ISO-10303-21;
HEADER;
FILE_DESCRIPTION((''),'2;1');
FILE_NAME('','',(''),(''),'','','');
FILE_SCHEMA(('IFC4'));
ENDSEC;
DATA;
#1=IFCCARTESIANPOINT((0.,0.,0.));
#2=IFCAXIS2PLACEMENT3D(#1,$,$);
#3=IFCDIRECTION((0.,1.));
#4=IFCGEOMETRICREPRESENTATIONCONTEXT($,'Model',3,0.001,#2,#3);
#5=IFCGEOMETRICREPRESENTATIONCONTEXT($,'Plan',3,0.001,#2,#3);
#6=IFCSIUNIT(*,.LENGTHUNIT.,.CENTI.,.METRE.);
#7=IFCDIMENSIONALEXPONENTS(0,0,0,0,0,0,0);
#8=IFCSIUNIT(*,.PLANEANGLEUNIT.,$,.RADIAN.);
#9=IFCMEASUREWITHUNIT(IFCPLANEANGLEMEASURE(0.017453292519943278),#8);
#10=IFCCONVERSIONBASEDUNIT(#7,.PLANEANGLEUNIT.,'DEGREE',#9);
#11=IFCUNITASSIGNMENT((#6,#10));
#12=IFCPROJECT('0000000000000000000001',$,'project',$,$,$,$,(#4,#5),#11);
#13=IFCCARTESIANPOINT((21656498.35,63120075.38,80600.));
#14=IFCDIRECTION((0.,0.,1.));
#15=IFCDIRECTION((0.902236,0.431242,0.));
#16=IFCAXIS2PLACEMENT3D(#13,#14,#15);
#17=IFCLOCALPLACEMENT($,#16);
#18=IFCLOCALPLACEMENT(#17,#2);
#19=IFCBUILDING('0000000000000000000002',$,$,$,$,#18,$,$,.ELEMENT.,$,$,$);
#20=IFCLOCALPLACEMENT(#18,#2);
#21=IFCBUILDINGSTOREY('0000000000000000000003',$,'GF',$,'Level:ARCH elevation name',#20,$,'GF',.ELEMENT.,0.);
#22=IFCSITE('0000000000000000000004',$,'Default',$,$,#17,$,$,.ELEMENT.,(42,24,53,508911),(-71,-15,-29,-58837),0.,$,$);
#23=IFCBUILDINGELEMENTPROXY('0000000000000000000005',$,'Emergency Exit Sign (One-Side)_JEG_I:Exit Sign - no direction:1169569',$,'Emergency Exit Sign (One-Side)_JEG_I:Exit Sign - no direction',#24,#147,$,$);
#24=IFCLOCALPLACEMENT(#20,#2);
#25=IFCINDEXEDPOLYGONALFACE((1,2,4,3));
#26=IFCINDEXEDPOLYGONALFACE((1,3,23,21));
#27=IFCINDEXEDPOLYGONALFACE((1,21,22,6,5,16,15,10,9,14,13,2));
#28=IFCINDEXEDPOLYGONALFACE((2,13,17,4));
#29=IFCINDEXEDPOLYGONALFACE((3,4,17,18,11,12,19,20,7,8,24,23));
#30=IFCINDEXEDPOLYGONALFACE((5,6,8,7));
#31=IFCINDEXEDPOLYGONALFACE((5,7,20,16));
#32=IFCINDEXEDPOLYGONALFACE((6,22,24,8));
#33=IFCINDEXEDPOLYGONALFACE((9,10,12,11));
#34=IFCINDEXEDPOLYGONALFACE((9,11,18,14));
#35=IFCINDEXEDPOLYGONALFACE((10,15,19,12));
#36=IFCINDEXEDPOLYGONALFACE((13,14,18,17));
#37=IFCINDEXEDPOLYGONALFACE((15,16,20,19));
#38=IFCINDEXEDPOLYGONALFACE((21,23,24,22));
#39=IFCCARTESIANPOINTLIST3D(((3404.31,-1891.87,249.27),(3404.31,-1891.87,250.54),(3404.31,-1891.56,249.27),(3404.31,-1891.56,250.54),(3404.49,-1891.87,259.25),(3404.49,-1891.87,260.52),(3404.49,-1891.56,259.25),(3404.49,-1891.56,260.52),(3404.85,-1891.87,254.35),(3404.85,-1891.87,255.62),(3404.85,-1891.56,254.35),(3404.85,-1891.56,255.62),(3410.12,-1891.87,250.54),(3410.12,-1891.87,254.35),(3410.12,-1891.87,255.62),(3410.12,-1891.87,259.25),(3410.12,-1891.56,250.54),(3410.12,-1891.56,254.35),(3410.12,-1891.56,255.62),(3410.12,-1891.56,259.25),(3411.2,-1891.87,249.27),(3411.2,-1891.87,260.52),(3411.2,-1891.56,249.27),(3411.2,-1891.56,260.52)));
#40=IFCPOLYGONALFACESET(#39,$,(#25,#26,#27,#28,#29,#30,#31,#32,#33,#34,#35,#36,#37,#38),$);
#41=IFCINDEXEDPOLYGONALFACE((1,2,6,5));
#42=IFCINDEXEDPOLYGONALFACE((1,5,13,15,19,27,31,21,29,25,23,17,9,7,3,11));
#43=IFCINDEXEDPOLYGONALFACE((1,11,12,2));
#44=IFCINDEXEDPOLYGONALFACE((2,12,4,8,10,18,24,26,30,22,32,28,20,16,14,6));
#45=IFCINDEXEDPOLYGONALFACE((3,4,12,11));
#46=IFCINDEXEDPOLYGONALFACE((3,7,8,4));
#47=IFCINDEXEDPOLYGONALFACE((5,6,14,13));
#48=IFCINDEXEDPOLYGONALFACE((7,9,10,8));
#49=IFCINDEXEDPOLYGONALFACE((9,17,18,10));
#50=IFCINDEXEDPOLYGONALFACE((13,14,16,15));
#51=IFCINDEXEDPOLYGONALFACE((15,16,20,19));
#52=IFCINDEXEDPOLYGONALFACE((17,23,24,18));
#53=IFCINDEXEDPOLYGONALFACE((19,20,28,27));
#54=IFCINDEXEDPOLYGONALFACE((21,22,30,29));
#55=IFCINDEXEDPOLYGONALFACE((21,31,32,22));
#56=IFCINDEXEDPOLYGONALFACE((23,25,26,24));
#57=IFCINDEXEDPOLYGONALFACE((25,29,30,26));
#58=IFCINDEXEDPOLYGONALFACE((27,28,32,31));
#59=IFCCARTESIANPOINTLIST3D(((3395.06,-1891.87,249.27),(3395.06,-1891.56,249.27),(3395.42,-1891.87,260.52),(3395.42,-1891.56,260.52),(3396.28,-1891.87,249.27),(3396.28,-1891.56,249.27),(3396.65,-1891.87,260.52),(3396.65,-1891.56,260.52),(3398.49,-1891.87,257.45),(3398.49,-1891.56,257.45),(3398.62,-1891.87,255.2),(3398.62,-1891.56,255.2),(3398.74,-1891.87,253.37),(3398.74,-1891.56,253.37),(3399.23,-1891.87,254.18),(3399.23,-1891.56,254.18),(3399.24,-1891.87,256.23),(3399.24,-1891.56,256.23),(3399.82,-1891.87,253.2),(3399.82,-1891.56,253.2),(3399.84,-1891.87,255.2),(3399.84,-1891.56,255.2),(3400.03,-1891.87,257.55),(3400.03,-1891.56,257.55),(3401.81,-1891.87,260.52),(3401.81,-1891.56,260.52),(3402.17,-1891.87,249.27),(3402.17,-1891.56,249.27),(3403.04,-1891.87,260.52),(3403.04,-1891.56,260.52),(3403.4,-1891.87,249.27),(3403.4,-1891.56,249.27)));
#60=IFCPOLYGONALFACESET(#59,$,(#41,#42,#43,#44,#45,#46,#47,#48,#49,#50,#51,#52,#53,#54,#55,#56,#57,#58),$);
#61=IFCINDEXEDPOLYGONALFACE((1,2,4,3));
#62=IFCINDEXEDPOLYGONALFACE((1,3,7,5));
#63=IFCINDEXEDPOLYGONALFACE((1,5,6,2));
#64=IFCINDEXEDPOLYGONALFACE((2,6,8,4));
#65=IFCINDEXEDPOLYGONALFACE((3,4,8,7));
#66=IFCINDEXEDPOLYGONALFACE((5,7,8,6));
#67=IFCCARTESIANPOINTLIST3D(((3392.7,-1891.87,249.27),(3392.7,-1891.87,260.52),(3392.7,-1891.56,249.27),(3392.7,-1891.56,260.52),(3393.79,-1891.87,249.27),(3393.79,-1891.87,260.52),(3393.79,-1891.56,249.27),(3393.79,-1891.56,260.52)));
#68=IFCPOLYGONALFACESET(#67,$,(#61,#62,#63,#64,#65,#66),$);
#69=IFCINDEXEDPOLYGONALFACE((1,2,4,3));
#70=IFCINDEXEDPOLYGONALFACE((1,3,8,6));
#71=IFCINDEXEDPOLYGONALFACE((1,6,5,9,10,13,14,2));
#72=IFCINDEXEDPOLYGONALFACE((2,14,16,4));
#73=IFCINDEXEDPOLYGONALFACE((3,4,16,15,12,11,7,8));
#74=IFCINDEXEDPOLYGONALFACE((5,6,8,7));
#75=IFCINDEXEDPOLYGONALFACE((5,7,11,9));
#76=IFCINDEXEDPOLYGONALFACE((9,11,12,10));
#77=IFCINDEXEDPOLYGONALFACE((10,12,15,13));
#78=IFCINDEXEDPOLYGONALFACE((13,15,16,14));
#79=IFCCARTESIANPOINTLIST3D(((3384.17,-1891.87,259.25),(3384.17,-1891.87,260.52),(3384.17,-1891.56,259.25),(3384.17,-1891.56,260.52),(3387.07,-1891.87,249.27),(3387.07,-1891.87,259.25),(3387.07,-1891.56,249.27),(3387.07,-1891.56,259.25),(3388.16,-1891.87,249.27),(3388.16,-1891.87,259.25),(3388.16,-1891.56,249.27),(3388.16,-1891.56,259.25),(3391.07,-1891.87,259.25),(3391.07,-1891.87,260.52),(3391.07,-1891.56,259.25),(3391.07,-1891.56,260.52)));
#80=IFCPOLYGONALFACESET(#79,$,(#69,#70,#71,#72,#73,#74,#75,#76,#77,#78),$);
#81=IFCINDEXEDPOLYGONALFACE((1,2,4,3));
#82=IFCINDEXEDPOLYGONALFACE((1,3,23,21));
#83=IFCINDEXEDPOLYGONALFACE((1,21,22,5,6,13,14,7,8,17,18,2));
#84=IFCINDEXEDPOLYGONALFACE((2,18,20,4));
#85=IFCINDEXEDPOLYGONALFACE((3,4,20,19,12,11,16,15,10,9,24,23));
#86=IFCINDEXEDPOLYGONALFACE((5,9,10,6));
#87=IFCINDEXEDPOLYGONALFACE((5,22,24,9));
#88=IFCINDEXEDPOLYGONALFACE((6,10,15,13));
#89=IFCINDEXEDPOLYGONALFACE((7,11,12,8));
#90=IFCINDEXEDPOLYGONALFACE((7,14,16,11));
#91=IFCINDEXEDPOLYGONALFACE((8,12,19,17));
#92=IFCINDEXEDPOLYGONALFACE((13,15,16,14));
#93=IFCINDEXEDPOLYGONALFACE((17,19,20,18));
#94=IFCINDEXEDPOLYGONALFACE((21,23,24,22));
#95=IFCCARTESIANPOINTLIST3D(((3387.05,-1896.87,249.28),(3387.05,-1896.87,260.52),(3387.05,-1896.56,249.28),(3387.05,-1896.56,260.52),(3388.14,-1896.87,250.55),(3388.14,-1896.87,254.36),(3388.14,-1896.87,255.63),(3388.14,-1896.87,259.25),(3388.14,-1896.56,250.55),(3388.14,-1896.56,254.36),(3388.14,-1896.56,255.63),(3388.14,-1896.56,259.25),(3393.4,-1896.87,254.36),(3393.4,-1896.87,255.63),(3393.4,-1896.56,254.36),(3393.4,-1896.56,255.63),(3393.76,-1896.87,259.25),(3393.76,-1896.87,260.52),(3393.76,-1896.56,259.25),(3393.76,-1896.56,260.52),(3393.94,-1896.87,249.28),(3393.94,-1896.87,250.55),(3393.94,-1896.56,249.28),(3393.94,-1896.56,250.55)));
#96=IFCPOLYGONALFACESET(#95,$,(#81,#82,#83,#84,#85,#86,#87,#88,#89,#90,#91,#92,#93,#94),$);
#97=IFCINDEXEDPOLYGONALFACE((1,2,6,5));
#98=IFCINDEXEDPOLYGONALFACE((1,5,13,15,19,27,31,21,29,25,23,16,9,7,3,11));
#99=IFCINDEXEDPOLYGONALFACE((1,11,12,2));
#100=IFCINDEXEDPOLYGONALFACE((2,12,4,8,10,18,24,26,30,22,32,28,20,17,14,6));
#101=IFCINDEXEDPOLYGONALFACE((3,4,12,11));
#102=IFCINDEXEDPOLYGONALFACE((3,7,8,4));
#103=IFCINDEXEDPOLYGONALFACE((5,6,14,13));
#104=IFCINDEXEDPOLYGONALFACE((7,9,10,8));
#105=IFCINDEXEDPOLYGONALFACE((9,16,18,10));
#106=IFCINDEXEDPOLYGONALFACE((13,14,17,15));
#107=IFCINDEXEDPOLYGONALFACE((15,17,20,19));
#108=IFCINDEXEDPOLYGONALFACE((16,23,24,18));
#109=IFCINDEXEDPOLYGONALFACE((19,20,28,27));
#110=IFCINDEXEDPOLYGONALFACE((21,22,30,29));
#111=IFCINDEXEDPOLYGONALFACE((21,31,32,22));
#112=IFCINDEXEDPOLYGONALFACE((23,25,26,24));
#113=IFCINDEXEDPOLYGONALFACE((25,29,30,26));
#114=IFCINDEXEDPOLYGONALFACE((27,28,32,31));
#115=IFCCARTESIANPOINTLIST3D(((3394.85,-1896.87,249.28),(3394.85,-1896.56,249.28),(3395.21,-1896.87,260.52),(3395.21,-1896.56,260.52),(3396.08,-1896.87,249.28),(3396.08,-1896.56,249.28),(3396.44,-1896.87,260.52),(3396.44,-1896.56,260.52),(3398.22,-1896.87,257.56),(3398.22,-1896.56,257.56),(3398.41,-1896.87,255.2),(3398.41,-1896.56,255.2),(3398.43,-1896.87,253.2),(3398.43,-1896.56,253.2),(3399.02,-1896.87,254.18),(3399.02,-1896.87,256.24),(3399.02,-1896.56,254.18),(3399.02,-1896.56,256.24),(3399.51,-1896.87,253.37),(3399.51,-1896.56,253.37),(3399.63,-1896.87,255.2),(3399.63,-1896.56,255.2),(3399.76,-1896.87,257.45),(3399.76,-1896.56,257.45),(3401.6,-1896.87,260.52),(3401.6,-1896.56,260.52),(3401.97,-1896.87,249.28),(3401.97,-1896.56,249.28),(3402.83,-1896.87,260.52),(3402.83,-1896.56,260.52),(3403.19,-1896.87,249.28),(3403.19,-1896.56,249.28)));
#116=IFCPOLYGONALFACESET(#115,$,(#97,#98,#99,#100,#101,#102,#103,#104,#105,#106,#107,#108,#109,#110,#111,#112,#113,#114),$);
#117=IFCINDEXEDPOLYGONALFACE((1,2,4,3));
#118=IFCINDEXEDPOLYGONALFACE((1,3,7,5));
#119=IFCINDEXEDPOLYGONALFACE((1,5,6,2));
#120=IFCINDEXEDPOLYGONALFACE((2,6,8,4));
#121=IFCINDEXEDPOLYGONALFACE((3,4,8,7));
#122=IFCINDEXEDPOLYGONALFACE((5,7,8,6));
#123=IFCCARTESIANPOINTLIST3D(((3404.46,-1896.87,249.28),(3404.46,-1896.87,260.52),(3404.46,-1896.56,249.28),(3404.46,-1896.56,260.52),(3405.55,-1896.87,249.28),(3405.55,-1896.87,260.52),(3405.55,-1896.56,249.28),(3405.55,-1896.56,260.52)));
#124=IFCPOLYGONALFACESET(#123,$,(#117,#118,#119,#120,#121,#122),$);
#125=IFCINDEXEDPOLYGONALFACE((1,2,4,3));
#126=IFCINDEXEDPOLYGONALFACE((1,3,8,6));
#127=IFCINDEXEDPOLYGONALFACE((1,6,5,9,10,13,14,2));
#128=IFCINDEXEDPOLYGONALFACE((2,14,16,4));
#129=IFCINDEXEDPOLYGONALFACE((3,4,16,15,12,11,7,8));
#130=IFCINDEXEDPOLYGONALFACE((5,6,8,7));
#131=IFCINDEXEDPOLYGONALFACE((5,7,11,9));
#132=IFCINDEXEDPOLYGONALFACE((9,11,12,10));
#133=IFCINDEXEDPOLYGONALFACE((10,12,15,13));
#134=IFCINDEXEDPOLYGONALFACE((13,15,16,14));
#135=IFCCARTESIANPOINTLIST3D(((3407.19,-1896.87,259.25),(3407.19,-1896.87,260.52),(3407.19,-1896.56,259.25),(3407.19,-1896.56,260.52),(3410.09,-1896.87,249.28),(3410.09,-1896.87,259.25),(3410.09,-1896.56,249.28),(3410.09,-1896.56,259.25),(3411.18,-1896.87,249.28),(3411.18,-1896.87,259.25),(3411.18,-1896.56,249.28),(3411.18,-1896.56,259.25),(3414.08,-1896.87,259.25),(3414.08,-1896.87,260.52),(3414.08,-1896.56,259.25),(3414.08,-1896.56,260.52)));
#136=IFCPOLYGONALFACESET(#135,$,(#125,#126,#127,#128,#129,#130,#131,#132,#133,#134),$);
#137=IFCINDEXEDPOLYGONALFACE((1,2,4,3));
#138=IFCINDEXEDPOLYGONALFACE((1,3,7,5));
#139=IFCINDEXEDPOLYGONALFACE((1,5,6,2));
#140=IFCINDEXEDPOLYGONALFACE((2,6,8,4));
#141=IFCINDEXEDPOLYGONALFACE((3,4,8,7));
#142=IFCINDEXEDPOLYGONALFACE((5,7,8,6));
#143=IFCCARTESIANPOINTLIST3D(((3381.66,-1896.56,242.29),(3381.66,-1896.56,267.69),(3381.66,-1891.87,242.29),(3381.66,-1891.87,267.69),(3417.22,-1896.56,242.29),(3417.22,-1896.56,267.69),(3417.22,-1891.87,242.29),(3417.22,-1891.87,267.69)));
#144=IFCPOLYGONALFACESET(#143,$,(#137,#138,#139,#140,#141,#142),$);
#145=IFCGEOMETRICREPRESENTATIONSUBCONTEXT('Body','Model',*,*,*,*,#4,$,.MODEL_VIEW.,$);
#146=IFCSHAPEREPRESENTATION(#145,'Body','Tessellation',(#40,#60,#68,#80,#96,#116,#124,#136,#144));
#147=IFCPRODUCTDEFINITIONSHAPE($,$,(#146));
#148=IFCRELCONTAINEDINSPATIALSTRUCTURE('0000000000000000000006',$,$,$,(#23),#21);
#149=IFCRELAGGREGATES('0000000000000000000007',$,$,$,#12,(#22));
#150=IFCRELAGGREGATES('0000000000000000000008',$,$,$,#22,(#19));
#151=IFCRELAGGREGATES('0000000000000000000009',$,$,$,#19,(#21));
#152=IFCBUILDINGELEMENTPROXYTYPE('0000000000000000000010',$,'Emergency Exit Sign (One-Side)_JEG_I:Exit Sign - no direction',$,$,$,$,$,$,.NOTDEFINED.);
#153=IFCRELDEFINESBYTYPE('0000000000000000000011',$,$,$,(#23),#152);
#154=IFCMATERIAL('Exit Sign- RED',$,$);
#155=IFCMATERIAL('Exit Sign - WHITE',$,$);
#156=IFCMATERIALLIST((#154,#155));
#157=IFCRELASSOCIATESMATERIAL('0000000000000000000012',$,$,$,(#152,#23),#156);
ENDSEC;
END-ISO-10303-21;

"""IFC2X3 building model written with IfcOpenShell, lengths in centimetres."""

from ifc_helpers import new_model, entity, si_unit, converted_unit, direction, frame, frame_2d, origin, origin_2d_with_axis, place, context, subcontext, project, spatial, polyline, rectangle, outline, extrude, source, transform, mapped, material, material_list, type_object, type_shapes, element, save


model = new_model("IFC2X3")

# Units and contexts
model_context = context("Model", 3, precision=0.001, world=origin(), true_north=direction((0.0, 1.0)))
plan_context = context("Plan", 3, precision=0.001, world=origin(), true_north=direction((0.0, 1.0)))
body_context = subcontext(model_context, "Body", "Model", "MODEL_VIEW")
ifc_project = project(units=[si_unit("LENGTHUNIT", "METRE", prefix="CENTI"), converted_unit("PLANEANGLEUNIT", "DEGREE", entity("IfcPlaneAngleMeasure", 0.017453292519943278), si_unit("PLANEANGLEUNIT", "RADIAN"), dimensions=[0, 0, 0, 0, 0, 0, 0])], contexts=[model_context, plan_context])

# Site, building, storey
site_placement = place(None, frame((21656498.35, 63120075.38, 80600.0), z_axis=(0.0, 0.0, 1.0), x_axis=(0.902236, 0.431242, 0.0)))
site = spatial("IfcSite", under=ifc_project, at=site_placement, Name="Default", CompositionType="ELEMENT", RefLatitude=(42, 24, 53, 508911), RefLongitude=(-71, -15, -29, -58837), RefElevation=0.0)
building_placement = place(site_placement, origin())
building = spatial("IfcBuilding", under=site, at=building_placement, CompositionType="ELEMENT")
storey_placement = place(building_placement, origin())
storey = spatial("IfcBuildingStorey", under=building, at=storey_placement, Name="GF", ObjectType="Level:ARCH elevation name", LongName="GF", CompositionType="ELEMENT", Elevation=0.0)

# Building element proxy
ifc_material_1 = material(Name="Exit Sign- RED")
ifc_material_2 = material(Name="Exit Sign - WHITE")
ifc_material_list_1 = material_list([ifc_material_1, ifc_material_2])
building_element_proxy_type_1 = type_object("IfcBuildingElementProxyType", Name="Emergency Exit Sign (One-Side)_JEG_I:Exit Sign - no direction", PredefinedType="NOTDEFINED", material=ifc_material_list_1)
shared_shape_1 = source(origin(), body_context, "Body", "SweptSolid", [
    extrude(outline(polyline([(-5.65, -3.69), (5.59, -3.69), (5.59, 3.02), (4.32, 3.02), (4.32, -2.6), (0.7, -2.6), (0.7, 2.66), (-0.57, 2.66), (-0.57, -2.6), (-4.38, -2.6), (-4.38, 3.21), (-5.65, 3.21), (-5.65, -3.69)])), frame((-8.08, -5.22, 12.64), z_axis=(0.0, 1.0, 0.0), x_axis=(0.0, 0.0, 1.0)), (0.0, 0.0, 1.0), 0.32),
    extrude(outline(polyline([(-7.14, 0.57), (-6.5, -0.49), (-1.93, -0.48), (-0.78, -0.48), (-1.23, -1.32), (-3.47, -5.53), (-2.84, -6.59), (0.41, -0.48), (6.62, -0.48), (5.99, 0.57), (2.4, 0.57), (0.98, 0.58), (1.7, 1.94), (3.32, 5.0), (2.69, 6.05), (-0.22, 0.57), (-7.14, 0.57)])), frame((0.2, -5.22, 12.81), z_axis=(0.0, -1.0, 0.0), x_axis=(0.515099, 0.0, 0.857131)), (0.0, 0.0, -1.0), 0.32),
    extrude(rectangle(XDim=0.32, YDim=1.09, at=frame_2d((0.0, 0.0), x_axis=(1.0, 0.0))), frame((6.19, -5.06, 6.99), z_axis=(0.0, 0.0, 1.0), x_axis=(0.0, 1.0, 0.0)), (0.0, 0.0, 1.0), 11.25),
    extrude(outline(polyline([(-7.8, 0.54), (-7.8, -0.54), (2.18, -0.54), (2.18, -3.45), (3.45, -3.45), (3.45, 3.45), (2.18, 3.45), (2.18, 0.54), (-7.8, 0.54)])), frame((11.82, -5.22, 14.79), z_axis=(0.0, -1.0, 0.0), x_axis=(0.0, 0.0, 1.0)), (0.0, 0.0, -1.0), 0.32),
    extrude(outline(polyline([(-3.69, -5.65), (3.21, -5.65), (3.21, -4.38), (-2.6, -4.38), (-2.6, -0.57), (2.66, -0.57), (2.66, 0.7), (-2.6, 0.7), (-2.6, 4.32), (3.02, 4.32), (3.02, 5.59), (-3.69, 5.59), (-3.69, -5.65)])), frame((8.7, -0.22, 12.65), z_axis=(0.0, 1.0, 0.0), x_axis=(-1.0, 0.0, 0.0)), (0.0, 0.0, 1.0), 0.32),
    extrude(outline(polyline([(-4.16, -5.82), (-2.93, -5.82), (-0.58, -1.9), (0.01, -0.92), (0.5, -1.73), (2.96, -5.82), (4.18, -5.82), (0.62, 0.1), (3.82, 5.42), (2.59, 5.42), (0.75, 2.35), (0.01, 1.14), (-0.79, 2.46), (-2.57, 5.42), (-3.8, 5.42), (-0.6, 0.1), (-4.16, -5.82)])), frame((0.43, -0.22, 12.82), z_axis=(0.0, 1.0, 0.0), x_axis=(-1.0, 0.0, 0.0)), (0.0, 0.0, 1.0), 0.32),
    extrude(rectangle(XDim=0.32, YDim=1.09, at=origin_2d_with_axis()), frame((-5.57, -0.06, 6.99), z_axis=(0.0, 0.0, 1.0), x_axis=(0.0, -1.0, 0.0)), (0.0, 0.0, 1.0), 11.25),
    extrude(outline(polyline([(-0.54, -7.8), (0.54, -7.8), (0.54, 2.18), (3.45, 2.18), (3.45, 3.45), (-3.45, 3.45), (-3.45, 2.18), (-0.54, 2.18), (-0.54, -7.8)])), frame((-11.2, -0.22, 14.79), z_axis=(0.0, 1.0, 0.0), x_axis=(-1.0, 0.0, 0.0)), (0.0, 0.0, 1.0), 0.32),
    extrude(rectangle(XDim=4.68, YDim=35.56, at=origin_2d_with_axis()), frame((0.0, -2.56, 0.01), z_axis=(0.0, 0.0, 1.0), x_axis=(0.0, 1.0, 0.0)), (0.0, 0.0, 1.0), 25.4),
])
type_shapes(building_element_proxy_type_1, [shared_shape_1])
for number, where, z_axis, x_axis, name in (
    (1, (3399.44, -1896.78, 242.28), (0.0, 0.0, 1.0), (-1.0, 0.0, 0.0), "Emergency Exit Sign (One-Side)_JEG_I:Exit Sign - no direction:1169569"),
):
    element("IfcBuildingElementProxy", number, at=place(storey_placement, frame(where, z_axis=z_axis, x_axis=x_axis)), inside=storey, type_object=building_element_proxy_type_1, material=ifc_material_list_1, Name=name, ObjectType="Emergency Exit Sign (One-Side)_JEG_I:Exit Sign - no direction", context=body_context, shape_type="MappedRepresentation", body=[
        mapped(shared_shape_1, transform((0.0, 0.0, 0.0), scale=1.0)),
    ])

save(model, "model.ifc")
